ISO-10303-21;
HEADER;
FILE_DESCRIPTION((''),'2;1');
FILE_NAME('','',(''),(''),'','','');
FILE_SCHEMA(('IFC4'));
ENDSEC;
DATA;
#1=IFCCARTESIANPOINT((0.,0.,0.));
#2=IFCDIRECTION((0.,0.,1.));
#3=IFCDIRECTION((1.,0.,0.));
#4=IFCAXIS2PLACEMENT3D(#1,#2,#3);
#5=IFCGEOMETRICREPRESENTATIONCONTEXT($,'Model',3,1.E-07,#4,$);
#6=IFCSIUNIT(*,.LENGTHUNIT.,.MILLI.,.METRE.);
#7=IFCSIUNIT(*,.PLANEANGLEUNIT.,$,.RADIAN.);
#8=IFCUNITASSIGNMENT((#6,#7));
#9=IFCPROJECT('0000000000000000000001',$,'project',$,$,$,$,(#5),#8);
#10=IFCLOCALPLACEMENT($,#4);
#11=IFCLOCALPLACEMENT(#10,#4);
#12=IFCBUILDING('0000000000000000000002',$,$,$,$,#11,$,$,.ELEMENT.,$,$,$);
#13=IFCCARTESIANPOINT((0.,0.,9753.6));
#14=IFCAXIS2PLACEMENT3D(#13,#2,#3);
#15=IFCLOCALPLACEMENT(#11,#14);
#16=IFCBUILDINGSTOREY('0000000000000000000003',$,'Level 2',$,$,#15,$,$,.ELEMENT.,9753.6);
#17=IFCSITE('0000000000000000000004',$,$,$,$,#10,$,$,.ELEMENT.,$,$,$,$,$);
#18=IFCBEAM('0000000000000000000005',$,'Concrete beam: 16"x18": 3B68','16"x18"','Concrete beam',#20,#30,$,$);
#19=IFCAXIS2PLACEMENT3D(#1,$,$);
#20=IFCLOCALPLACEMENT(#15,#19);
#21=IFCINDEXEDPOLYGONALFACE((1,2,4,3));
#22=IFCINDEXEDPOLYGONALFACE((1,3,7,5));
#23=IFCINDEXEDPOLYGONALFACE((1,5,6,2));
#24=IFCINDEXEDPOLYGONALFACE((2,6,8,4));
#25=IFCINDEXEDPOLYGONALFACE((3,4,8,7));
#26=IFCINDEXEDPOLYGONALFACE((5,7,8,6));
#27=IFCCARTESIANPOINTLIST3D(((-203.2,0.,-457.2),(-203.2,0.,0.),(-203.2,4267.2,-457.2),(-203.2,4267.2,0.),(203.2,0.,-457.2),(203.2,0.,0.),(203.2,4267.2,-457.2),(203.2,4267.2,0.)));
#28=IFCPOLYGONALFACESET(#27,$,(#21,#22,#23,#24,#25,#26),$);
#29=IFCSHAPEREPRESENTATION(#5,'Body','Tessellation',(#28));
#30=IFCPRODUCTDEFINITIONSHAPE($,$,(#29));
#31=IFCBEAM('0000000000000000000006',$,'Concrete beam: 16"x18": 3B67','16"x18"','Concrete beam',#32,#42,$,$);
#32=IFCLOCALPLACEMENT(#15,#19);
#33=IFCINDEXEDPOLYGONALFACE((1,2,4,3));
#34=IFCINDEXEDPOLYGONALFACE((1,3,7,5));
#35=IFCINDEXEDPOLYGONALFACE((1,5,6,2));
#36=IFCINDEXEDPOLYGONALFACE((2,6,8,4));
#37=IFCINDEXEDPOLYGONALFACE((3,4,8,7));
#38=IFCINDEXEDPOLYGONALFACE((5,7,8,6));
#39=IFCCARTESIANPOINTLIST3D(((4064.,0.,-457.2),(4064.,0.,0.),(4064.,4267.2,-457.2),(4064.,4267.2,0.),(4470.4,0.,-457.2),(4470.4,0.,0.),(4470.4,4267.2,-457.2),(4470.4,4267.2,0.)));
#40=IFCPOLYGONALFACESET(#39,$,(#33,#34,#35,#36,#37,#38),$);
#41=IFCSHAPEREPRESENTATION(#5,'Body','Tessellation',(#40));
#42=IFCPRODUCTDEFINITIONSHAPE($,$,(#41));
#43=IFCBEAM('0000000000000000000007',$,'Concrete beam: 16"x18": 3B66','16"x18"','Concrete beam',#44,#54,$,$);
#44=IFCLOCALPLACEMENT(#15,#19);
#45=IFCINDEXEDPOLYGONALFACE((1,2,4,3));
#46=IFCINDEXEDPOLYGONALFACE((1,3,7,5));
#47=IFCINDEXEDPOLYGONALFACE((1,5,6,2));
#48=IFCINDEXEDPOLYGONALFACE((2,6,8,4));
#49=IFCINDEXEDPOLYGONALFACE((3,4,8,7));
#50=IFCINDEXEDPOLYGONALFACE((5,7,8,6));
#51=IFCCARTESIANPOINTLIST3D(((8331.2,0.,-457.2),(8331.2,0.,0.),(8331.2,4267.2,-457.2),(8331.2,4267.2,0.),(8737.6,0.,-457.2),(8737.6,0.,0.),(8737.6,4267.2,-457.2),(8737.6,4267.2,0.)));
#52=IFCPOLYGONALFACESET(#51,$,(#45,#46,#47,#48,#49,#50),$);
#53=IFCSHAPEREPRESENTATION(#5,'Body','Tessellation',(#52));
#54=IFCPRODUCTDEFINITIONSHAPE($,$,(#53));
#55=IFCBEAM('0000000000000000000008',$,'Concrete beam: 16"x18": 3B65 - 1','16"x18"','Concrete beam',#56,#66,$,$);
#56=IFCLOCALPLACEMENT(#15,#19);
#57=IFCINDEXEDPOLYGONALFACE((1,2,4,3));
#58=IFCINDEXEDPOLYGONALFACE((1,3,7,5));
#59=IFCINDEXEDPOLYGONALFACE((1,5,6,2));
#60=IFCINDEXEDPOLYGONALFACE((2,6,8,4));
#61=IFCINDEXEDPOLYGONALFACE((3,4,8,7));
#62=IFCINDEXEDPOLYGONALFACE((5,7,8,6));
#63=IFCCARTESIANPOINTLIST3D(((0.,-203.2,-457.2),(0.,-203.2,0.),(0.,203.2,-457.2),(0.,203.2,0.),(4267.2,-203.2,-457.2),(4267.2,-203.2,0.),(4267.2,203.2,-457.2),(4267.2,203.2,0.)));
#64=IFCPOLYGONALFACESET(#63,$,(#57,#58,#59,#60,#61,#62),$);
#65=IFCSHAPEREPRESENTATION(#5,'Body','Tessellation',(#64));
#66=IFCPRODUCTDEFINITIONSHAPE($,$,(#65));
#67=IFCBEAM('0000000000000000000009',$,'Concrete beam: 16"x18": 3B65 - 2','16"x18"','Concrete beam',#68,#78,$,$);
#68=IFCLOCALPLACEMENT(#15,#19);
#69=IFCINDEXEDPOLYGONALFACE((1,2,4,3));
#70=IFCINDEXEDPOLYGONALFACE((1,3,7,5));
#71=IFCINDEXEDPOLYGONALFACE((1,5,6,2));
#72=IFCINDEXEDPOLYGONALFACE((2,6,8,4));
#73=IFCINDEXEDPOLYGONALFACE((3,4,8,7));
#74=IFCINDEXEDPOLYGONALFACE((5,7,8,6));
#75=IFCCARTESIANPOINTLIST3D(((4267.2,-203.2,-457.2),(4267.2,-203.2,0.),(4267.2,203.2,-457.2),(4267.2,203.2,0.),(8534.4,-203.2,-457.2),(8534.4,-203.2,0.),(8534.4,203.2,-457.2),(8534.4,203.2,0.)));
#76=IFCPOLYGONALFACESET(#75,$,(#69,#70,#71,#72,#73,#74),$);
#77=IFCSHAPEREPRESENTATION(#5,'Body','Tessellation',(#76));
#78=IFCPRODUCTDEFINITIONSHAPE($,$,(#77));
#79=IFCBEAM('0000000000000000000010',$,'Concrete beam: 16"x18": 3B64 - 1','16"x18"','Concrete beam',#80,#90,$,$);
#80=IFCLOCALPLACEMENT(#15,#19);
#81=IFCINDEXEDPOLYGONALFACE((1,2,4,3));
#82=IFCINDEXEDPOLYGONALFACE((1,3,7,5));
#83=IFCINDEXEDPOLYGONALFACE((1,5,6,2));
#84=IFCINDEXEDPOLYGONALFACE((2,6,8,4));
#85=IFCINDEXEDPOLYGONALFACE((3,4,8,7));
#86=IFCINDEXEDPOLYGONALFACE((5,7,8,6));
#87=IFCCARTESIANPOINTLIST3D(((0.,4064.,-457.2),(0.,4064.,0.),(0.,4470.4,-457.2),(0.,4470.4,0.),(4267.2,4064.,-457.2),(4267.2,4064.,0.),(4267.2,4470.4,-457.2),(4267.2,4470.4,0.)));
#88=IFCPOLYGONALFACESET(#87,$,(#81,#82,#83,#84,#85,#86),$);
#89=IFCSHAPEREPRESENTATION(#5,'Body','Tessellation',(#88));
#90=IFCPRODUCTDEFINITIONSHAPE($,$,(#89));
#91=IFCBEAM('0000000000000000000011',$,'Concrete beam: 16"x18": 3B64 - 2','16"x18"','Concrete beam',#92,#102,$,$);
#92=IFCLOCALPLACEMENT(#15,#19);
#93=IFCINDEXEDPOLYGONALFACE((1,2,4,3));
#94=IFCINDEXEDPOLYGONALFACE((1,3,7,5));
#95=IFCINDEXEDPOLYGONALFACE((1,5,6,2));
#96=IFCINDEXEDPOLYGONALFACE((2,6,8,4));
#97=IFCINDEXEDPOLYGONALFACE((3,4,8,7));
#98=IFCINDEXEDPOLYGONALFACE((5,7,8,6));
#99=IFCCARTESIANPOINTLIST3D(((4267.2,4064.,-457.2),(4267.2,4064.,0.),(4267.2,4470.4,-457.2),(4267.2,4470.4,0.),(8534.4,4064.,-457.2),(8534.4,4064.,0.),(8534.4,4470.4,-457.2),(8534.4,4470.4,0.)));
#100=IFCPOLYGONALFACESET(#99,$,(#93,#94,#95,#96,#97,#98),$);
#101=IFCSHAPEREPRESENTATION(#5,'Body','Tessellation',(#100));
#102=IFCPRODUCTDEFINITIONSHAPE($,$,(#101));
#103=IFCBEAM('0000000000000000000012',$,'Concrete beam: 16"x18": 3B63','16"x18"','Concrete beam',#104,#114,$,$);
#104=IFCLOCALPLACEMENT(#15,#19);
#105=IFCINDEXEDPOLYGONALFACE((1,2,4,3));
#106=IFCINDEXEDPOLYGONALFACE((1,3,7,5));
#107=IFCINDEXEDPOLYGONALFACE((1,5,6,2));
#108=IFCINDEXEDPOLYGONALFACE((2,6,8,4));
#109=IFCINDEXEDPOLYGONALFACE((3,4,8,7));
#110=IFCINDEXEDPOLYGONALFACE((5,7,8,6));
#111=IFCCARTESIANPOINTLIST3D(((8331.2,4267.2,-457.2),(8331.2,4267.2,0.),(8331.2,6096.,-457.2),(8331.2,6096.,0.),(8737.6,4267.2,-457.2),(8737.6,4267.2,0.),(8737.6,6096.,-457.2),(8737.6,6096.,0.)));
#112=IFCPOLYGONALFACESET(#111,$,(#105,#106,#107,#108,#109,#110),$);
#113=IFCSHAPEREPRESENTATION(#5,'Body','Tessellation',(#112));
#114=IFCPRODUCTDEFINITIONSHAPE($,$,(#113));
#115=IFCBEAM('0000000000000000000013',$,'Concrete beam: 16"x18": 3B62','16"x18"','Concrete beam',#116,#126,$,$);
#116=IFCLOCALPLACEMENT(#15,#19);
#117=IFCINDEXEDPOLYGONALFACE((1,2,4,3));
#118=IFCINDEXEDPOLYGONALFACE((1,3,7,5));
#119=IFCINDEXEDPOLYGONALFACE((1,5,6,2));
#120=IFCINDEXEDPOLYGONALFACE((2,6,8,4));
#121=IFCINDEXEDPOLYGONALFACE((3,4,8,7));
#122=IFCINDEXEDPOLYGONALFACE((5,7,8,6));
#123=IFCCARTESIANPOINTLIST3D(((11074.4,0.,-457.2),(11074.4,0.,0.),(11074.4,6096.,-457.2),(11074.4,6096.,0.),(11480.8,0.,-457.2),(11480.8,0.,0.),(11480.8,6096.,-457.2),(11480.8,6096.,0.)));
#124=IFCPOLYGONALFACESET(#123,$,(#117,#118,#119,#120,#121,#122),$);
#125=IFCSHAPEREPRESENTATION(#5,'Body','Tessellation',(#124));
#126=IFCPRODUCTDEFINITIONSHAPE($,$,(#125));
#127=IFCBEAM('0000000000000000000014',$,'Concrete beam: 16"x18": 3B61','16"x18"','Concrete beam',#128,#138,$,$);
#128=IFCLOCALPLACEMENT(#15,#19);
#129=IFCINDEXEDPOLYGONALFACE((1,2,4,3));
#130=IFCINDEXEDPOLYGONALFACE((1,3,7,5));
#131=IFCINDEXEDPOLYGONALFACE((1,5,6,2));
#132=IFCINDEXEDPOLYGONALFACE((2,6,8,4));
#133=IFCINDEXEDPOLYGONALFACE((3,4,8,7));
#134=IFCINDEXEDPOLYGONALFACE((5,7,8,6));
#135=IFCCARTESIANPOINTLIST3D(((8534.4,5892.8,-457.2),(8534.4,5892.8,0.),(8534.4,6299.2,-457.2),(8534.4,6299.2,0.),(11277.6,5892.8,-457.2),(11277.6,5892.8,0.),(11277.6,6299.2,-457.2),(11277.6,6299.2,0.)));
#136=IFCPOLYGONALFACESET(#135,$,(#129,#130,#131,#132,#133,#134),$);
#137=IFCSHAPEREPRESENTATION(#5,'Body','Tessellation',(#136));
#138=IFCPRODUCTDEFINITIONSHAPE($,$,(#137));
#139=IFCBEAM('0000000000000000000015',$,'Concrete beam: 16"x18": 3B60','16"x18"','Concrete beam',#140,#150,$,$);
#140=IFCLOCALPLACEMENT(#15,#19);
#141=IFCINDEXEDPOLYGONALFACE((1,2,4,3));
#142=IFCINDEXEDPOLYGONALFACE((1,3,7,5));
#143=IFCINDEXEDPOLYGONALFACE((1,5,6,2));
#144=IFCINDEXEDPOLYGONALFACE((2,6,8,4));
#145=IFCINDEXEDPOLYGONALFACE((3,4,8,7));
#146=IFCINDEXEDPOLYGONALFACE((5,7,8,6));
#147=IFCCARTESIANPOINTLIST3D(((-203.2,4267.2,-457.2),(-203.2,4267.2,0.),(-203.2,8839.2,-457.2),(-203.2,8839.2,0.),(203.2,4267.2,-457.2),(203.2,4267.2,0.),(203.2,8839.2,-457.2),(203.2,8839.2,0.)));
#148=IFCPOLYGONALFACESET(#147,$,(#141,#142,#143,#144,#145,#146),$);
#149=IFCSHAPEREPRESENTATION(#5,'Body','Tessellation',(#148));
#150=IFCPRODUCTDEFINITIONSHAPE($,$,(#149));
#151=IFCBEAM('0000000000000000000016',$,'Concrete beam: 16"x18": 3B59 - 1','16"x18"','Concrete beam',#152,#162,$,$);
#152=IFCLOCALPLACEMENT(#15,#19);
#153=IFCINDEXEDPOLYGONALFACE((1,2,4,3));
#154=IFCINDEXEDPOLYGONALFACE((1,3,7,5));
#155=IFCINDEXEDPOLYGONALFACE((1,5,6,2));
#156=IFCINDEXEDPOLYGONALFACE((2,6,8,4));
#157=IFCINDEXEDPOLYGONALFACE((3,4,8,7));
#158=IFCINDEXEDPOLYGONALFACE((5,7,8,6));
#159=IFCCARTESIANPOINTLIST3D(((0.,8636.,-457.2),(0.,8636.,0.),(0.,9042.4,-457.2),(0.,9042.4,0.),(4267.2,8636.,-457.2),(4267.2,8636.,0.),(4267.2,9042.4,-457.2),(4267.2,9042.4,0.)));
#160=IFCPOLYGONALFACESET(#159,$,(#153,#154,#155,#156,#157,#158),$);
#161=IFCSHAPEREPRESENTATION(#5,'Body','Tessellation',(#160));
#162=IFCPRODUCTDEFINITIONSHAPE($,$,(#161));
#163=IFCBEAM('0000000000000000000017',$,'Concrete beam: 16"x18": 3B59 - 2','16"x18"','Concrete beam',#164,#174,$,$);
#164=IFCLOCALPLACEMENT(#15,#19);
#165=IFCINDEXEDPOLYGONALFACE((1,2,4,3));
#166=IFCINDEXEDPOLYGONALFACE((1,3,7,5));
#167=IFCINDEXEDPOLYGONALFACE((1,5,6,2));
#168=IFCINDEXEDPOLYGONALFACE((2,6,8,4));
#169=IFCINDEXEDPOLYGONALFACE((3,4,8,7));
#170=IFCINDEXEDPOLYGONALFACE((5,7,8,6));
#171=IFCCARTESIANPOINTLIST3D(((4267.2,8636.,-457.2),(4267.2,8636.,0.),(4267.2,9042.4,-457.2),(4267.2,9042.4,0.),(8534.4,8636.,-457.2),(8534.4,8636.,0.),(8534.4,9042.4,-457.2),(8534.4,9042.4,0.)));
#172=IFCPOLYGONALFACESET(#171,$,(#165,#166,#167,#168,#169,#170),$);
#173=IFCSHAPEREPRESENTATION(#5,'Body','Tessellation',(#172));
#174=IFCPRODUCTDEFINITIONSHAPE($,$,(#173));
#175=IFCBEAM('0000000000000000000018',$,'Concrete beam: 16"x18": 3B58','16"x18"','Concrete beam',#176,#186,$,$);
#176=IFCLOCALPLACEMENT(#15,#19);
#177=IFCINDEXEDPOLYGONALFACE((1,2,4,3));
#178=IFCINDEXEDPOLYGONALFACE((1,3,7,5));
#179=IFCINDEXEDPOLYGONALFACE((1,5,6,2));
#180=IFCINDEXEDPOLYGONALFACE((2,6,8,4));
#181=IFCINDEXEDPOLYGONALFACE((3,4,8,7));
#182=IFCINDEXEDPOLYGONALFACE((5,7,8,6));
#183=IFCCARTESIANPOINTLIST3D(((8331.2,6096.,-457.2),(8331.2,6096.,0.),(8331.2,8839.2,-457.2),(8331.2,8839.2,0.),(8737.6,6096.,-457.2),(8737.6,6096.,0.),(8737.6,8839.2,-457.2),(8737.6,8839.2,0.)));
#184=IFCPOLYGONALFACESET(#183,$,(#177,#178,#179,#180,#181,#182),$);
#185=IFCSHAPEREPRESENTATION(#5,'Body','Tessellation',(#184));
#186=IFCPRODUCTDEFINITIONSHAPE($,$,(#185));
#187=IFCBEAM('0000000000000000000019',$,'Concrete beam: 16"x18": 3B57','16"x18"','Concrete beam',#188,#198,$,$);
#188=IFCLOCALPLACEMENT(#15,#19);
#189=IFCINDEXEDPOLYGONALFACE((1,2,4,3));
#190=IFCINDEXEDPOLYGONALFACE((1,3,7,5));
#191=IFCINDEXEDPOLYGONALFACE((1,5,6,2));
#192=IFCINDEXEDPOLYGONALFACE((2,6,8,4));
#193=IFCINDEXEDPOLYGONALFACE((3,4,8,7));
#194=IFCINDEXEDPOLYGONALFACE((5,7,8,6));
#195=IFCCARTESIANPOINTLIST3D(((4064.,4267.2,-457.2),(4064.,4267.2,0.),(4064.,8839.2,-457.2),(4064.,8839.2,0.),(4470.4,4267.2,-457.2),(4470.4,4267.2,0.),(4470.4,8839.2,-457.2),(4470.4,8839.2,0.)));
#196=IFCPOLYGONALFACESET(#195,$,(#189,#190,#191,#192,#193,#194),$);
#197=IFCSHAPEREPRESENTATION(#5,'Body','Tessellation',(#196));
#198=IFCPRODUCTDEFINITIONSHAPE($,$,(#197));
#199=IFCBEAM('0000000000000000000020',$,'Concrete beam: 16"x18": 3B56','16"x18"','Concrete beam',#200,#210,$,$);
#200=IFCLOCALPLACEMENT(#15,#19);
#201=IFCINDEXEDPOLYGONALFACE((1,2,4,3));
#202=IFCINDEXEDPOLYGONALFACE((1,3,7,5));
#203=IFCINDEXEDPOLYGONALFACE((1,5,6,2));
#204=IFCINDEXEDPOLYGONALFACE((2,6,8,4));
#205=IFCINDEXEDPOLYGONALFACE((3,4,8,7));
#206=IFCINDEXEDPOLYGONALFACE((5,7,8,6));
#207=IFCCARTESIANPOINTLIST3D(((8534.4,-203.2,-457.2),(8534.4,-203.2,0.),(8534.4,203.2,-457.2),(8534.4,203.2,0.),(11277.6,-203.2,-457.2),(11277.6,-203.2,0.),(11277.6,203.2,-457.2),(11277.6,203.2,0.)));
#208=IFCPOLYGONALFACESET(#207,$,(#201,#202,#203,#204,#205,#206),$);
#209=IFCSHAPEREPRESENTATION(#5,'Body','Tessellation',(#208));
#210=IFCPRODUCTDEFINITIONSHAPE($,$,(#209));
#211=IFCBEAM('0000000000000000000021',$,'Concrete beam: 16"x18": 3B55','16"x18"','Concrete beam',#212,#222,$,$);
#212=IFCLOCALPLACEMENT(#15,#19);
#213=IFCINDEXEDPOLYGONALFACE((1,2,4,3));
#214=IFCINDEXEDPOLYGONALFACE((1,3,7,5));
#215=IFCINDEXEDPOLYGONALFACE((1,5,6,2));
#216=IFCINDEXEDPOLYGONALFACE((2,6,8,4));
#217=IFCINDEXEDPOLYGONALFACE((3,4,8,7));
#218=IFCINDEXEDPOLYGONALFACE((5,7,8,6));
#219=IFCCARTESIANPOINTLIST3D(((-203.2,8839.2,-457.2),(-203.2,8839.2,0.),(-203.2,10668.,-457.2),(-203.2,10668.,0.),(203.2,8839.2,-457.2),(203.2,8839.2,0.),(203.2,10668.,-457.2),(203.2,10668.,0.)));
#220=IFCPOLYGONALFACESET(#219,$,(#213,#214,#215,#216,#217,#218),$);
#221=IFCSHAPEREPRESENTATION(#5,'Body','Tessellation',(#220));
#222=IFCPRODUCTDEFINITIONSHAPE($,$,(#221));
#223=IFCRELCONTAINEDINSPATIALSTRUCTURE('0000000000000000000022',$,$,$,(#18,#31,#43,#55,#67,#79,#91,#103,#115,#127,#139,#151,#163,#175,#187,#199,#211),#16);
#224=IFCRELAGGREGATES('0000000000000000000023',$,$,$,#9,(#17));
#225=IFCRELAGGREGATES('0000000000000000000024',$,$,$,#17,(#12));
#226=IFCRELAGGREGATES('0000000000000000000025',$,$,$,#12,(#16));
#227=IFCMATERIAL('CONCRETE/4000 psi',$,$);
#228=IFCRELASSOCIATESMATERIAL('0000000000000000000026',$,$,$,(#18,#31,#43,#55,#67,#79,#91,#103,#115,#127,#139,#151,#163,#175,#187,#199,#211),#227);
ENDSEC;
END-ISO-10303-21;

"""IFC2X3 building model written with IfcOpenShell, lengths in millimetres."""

from ifc_helpers import new_model, si_unit, frame, origin_with_axes, origin_2d_with_axis, place, context, project, spatial, rectangle, extrude, material, element, save


model = new_model("IFC2X3")

# Units and contexts
model_context = context("Model", 3, precision=1e-07, world=origin_with_axes())
ifc_project = project(units=[si_unit("LENGTHUNIT", "METRE", prefix="MILLI"), si_unit("PLANEANGLEUNIT", "RADIAN")], contexts=[model_context])

# Site, building, storey
site_placement = place(None, origin_with_axes())
site = spatial("IfcSite", under=ifc_project, at=site_placement, CompositionType="ELEMENT")
building_placement = place(site_placement, origin_with_axes())
building = spatial("IfcBuilding", under=site, at=building_placement, CompositionType="ELEMENT")
storey_placement = place(building_placement, frame((0.0, 0.0, 9753.6), z_axis=(0.0, 0.0, 1.0), x_axis=(1.0, 0.0, 0.0)))
storey = spatial("IfcBuildingStorey", under=building, at=storey_placement, Name="Level 2", CompositionType="ELEMENT", Elevation=9753.6)

# Beams
ifc_material = material(Name="CONCRETE/4000 psi")
for number, where, z_axis, x_axis, name in (
    (1, (0.0, 0.0, 9753.6), (0.0, 0.0, 1.0), (0.0, 1.0, 0.0), "Concrete beam: 16\"x18\": 3B68"),
    (2, (4267.2, 0.0, 9753.6), (0.0, 0.0, 1.0), (0.0, 1.0, 0.0), "Concrete beam: 16\"x18\": 3B67"),
    (3, (8534.4, 0.0, 9753.6), (0.0, 0.0, 1.0), (0.0, 1.0, 0.0), "Concrete beam: 16\"x18\": 3B66"),
    (4, (0.0, 0.0, 9753.6), (0.0, 0.0, 1.0), (1.0, 0.0, 0.0), "Concrete beam: 16\"x18\": 3B65 - 1"),
    (5, (4267.2, 0.0, 9753.6), (0.0, 0.0, 1.0), (1.0, 0.0, 0.0), "Concrete beam: 16\"x18\": 3B65 - 2"),
    (6, (0.0, 4267.2, 9753.6), (0.0, 0.0, 1.0), (1.0, 0.0, 0.0), "Concrete beam: 16\"x18\": 3B64 - 1"),
    (7, (4267.2, 4267.2, 9753.6), (0.0, 0.0, 1.0), (1.0, 0.0, 0.0), "Concrete beam: 16\"x18\": 3B64 - 2"),
):
    element("IfcBeam", number, at=place(building_placement, frame(where, z_axis=z_axis, x_axis=x_axis)), inside=storey, material=ifc_material, Name=name, Description="16\"x18\"", ObjectType="Concrete beam", context=model_context, shape_type="SweptSolid", body=[
        extrude(rectangle(XDim=406.4, YDim=457.2, at=origin_2d_with_axis()), frame((4267.2, 0.0, -228.6), z_axis=(-1.0, 0.0, 0.0), x_axis=(0.0, -1.0, 0.0)), (0.0, 0.0, 1.0), 4267.2),
    ])
beam_1_placement = place(building_placement, frame((8534.4, 4267.2, 9753.6), z_axis=(0.0, 0.0, 1.0), x_axis=(0.0, 1.0, 0.0)))
element("IfcBeam", 8, at=beam_1_placement, inside=storey, material=ifc_material, Name="Concrete beam: 16\"x18\": 3B63", Description="16\"x18\"", ObjectType="Concrete beam", context=model_context, shape_type="SweptSolid", body=[
    extrude(rectangle(XDim=406.4, YDim=457.2, at=origin_2d_with_axis()), frame((1828.8, 0.0, -228.6), z_axis=(-1.0, 0.0, 0.0), x_axis=(0.0, -1.0, 0.0)), (0.0, 0.0, 1.0), 1828.8),
])
beam_2_placement = place(building_placement, frame((11277.6, 0.0, 9753.6), z_axis=(0.0, 0.0, 1.0), x_axis=(0.0, 1.0, 0.0)))
element("IfcBeam", 9, at=beam_2_placement, inside=storey, material=ifc_material, Name="Concrete beam: 16\"x18\": 3B62", Description="16\"x18\"", ObjectType="Concrete beam", context=model_context, shape_type="SweptSolid", body=[
    extrude(rectangle(XDim=406.4, YDim=457.2, at=origin_2d_with_axis()), frame((6096.0, 0.0, -228.6), z_axis=(-1.0, 0.0, 0.0), x_axis=(0.0, -1.0, 0.0)), (0.0, 0.0, 1.0), 6096.0),
])
beam_3_placement = place(building_placement, frame((8534.4, 6096.0, 9753.6), z_axis=(0.0, 0.0, 1.0), x_axis=(1.0, 0.0, 0.0)))
element("IfcBeam", 10, at=beam_3_placement, inside=storey, material=ifc_material, Name="Concrete beam: 16\"x18\": 3B61", Description="16\"x18\"", ObjectType="Concrete beam", context=model_context, shape_type="SweptSolid", body=[
    extrude(rectangle(XDim=406.4, YDim=457.2, at=origin_2d_with_axis()), frame((2743.2, 0.0, -228.6), z_axis=(-1.0, 0.0, 0.0), x_axis=(0.0, -1.0, 0.0)), (0.0, 0.0, 1.0), 2743.2),
])
beam_4_placement = place(building_placement, frame((0.0, 4267.2, 9753.6), z_axis=(0.0, 0.0, 1.0), x_axis=(0.0, 1.0, 0.0)))
element("IfcBeam", 11, at=beam_4_placement, inside=storey, material=ifc_material, Name="Concrete beam: 16\"x18\": 3B60", Description="16\"x18\"", ObjectType="Concrete beam", context=model_context, shape_type="SweptSolid", body=[
    extrude(rectangle(XDim=406.4, YDim=457.2, at=origin_2d_with_axis()), frame((4572.0, 0.0, -228.6), z_axis=(-1.0, 0.0, 0.0), x_axis=(0.0, -1.0, 0.0)), (0.0, 0.0, 1.0), 4572.0),
])
for number, where, z_axis, x_axis, name in (
    (12, (0.0, 8839.2, 9753.6), (0.0, 0.0, 1.0), (1.0, 0.0, 0.0), "Concrete beam: 16\"x18\": 3B59 - 1"),
    (13, (4267.2, 8839.2, 9753.6), (0.0, 0.0, 1.0), (1.0, 0.0, 0.0), "Concrete beam: 16\"x18\": 3B59 - 2"),
):
    element("IfcBeam", number, at=place(building_placement, frame(where, z_axis=z_axis, x_axis=x_axis)), inside=storey, material=ifc_material, Name=name, Description="16\"x18\"", ObjectType="Concrete beam", context=model_context, shape_type="SweptSolid", body=[
        extrude(rectangle(XDim=406.4, YDim=457.2, at=origin_2d_with_axis()), frame((4267.2, 0.0, -228.6), z_axis=(-1.0, 0.0, 0.0), x_axis=(0.0, -1.0, 0.0)), (0.0, 0.0, 1.0), 4267.2),
    ])
beam_5_placement = place(building_placement, frame((8534.4, 6096.0, 9753.6), z_axis=(0.0, 0.0, 1.0), x_axis=(0.0, 1.0, 0.0)))
element("IfcBeam", 14, at=beam_5_placement, inside=storey, material=ifc_material, Name="Concrete beam: 16\"x18\": 3B58", Description="16\"x18\"", ObjectType="Concrete beam", context=model_context, shape_type="SweptSolid", body=[
    extrude(rectangle(XDim=406.4, YDim=457.2, at=origin_2d_with_axis()), frame((2743.2, 0.0, -228.6), z_axis=(-1.0, 0.0, 0.0), x_axis=(0.0, -1.0, 0.0)), (0.0, 0.0, 1.0), 2743.2),
])
beam_6_placement = place(building_placement, frame((4267.2, 4267.2, 9753.6), z_axis=(0.0, 0.0, 1.0), x_axis=(0.0, 1.0, 0.0)))
element("IfcBeam", 15, at=beam_6_placement, inside=storey, material=ifc_material, Name="Concrete beam: 16\"x18\": 3B57", Description="16\"x18\"", ObjectType="Concrete beam", context=model_context, shape_type="SweptSolid", body=[
    extrude(rectangle(XDim=406.4, YDim=457.2, at=origin_2d_with_axis()), frame((4572.0, 0.0, -228.6), z_axis=(-1.0, 0.0, 0.0), x_axis=(0.0, -1.0, 0.0)), (0.0, 0.0, 1.0), 4572.0),
])
beam_7_placement = place(building_placement, frame((8534.4, 0.0, 9753.6), z_axis=(0.0, 0.0, 1.0), x_axis=(1.0, 0.0, 0.0)))
element("IfcBeam", 16, at=beam_7_placement, inside=storey, material=ifc_material, Name="Concrete beam: 16\"x18\": 3B56", Description="16\"x18\"", ObjectType="Concrete beam", context=model_context, shape_type="SweptSolid", body=[
    extrude(rectangle(XDim=406.4, YDim=457.2, at=origin_2d_with_axis()), frame((2743.2, 0.0, -228.6), z_axis=(-1.0, 0.0, 0.0), x_axis=(0.0, -1.0, 0.0)), (0.0, 0.0, 1.0), 2743.2),
])
beam_8_placement = place(building_placement, frame((0.0, 10668.0, 9753.6), z_axis=(0.0, 0.0, 1.0), x_axis=(0.0, -1.0, 0.0)))
element("IfcBeam", 17, at=beam_8_placement, inside=storey, material=ifc_material, Name="Concrete beam: 16\"x18\": 3B55", Description="16\"x18\"", ObjectType="Concrete beam", context=model_context, shape_type="SweptSolid", body=[
    extrude(rectangle(XDim=406.4, YDim=457.2, at=origin_2d_with_axis()), frame((1828.8, 0.0, -228.6), z_axis=(-1.0, 0.0, 0.0), x_axis=(0.0, -1.0, 0.0)), (0.0, 0.0, 1.0), 1828.8),
])

save(model, "model.ifc")
